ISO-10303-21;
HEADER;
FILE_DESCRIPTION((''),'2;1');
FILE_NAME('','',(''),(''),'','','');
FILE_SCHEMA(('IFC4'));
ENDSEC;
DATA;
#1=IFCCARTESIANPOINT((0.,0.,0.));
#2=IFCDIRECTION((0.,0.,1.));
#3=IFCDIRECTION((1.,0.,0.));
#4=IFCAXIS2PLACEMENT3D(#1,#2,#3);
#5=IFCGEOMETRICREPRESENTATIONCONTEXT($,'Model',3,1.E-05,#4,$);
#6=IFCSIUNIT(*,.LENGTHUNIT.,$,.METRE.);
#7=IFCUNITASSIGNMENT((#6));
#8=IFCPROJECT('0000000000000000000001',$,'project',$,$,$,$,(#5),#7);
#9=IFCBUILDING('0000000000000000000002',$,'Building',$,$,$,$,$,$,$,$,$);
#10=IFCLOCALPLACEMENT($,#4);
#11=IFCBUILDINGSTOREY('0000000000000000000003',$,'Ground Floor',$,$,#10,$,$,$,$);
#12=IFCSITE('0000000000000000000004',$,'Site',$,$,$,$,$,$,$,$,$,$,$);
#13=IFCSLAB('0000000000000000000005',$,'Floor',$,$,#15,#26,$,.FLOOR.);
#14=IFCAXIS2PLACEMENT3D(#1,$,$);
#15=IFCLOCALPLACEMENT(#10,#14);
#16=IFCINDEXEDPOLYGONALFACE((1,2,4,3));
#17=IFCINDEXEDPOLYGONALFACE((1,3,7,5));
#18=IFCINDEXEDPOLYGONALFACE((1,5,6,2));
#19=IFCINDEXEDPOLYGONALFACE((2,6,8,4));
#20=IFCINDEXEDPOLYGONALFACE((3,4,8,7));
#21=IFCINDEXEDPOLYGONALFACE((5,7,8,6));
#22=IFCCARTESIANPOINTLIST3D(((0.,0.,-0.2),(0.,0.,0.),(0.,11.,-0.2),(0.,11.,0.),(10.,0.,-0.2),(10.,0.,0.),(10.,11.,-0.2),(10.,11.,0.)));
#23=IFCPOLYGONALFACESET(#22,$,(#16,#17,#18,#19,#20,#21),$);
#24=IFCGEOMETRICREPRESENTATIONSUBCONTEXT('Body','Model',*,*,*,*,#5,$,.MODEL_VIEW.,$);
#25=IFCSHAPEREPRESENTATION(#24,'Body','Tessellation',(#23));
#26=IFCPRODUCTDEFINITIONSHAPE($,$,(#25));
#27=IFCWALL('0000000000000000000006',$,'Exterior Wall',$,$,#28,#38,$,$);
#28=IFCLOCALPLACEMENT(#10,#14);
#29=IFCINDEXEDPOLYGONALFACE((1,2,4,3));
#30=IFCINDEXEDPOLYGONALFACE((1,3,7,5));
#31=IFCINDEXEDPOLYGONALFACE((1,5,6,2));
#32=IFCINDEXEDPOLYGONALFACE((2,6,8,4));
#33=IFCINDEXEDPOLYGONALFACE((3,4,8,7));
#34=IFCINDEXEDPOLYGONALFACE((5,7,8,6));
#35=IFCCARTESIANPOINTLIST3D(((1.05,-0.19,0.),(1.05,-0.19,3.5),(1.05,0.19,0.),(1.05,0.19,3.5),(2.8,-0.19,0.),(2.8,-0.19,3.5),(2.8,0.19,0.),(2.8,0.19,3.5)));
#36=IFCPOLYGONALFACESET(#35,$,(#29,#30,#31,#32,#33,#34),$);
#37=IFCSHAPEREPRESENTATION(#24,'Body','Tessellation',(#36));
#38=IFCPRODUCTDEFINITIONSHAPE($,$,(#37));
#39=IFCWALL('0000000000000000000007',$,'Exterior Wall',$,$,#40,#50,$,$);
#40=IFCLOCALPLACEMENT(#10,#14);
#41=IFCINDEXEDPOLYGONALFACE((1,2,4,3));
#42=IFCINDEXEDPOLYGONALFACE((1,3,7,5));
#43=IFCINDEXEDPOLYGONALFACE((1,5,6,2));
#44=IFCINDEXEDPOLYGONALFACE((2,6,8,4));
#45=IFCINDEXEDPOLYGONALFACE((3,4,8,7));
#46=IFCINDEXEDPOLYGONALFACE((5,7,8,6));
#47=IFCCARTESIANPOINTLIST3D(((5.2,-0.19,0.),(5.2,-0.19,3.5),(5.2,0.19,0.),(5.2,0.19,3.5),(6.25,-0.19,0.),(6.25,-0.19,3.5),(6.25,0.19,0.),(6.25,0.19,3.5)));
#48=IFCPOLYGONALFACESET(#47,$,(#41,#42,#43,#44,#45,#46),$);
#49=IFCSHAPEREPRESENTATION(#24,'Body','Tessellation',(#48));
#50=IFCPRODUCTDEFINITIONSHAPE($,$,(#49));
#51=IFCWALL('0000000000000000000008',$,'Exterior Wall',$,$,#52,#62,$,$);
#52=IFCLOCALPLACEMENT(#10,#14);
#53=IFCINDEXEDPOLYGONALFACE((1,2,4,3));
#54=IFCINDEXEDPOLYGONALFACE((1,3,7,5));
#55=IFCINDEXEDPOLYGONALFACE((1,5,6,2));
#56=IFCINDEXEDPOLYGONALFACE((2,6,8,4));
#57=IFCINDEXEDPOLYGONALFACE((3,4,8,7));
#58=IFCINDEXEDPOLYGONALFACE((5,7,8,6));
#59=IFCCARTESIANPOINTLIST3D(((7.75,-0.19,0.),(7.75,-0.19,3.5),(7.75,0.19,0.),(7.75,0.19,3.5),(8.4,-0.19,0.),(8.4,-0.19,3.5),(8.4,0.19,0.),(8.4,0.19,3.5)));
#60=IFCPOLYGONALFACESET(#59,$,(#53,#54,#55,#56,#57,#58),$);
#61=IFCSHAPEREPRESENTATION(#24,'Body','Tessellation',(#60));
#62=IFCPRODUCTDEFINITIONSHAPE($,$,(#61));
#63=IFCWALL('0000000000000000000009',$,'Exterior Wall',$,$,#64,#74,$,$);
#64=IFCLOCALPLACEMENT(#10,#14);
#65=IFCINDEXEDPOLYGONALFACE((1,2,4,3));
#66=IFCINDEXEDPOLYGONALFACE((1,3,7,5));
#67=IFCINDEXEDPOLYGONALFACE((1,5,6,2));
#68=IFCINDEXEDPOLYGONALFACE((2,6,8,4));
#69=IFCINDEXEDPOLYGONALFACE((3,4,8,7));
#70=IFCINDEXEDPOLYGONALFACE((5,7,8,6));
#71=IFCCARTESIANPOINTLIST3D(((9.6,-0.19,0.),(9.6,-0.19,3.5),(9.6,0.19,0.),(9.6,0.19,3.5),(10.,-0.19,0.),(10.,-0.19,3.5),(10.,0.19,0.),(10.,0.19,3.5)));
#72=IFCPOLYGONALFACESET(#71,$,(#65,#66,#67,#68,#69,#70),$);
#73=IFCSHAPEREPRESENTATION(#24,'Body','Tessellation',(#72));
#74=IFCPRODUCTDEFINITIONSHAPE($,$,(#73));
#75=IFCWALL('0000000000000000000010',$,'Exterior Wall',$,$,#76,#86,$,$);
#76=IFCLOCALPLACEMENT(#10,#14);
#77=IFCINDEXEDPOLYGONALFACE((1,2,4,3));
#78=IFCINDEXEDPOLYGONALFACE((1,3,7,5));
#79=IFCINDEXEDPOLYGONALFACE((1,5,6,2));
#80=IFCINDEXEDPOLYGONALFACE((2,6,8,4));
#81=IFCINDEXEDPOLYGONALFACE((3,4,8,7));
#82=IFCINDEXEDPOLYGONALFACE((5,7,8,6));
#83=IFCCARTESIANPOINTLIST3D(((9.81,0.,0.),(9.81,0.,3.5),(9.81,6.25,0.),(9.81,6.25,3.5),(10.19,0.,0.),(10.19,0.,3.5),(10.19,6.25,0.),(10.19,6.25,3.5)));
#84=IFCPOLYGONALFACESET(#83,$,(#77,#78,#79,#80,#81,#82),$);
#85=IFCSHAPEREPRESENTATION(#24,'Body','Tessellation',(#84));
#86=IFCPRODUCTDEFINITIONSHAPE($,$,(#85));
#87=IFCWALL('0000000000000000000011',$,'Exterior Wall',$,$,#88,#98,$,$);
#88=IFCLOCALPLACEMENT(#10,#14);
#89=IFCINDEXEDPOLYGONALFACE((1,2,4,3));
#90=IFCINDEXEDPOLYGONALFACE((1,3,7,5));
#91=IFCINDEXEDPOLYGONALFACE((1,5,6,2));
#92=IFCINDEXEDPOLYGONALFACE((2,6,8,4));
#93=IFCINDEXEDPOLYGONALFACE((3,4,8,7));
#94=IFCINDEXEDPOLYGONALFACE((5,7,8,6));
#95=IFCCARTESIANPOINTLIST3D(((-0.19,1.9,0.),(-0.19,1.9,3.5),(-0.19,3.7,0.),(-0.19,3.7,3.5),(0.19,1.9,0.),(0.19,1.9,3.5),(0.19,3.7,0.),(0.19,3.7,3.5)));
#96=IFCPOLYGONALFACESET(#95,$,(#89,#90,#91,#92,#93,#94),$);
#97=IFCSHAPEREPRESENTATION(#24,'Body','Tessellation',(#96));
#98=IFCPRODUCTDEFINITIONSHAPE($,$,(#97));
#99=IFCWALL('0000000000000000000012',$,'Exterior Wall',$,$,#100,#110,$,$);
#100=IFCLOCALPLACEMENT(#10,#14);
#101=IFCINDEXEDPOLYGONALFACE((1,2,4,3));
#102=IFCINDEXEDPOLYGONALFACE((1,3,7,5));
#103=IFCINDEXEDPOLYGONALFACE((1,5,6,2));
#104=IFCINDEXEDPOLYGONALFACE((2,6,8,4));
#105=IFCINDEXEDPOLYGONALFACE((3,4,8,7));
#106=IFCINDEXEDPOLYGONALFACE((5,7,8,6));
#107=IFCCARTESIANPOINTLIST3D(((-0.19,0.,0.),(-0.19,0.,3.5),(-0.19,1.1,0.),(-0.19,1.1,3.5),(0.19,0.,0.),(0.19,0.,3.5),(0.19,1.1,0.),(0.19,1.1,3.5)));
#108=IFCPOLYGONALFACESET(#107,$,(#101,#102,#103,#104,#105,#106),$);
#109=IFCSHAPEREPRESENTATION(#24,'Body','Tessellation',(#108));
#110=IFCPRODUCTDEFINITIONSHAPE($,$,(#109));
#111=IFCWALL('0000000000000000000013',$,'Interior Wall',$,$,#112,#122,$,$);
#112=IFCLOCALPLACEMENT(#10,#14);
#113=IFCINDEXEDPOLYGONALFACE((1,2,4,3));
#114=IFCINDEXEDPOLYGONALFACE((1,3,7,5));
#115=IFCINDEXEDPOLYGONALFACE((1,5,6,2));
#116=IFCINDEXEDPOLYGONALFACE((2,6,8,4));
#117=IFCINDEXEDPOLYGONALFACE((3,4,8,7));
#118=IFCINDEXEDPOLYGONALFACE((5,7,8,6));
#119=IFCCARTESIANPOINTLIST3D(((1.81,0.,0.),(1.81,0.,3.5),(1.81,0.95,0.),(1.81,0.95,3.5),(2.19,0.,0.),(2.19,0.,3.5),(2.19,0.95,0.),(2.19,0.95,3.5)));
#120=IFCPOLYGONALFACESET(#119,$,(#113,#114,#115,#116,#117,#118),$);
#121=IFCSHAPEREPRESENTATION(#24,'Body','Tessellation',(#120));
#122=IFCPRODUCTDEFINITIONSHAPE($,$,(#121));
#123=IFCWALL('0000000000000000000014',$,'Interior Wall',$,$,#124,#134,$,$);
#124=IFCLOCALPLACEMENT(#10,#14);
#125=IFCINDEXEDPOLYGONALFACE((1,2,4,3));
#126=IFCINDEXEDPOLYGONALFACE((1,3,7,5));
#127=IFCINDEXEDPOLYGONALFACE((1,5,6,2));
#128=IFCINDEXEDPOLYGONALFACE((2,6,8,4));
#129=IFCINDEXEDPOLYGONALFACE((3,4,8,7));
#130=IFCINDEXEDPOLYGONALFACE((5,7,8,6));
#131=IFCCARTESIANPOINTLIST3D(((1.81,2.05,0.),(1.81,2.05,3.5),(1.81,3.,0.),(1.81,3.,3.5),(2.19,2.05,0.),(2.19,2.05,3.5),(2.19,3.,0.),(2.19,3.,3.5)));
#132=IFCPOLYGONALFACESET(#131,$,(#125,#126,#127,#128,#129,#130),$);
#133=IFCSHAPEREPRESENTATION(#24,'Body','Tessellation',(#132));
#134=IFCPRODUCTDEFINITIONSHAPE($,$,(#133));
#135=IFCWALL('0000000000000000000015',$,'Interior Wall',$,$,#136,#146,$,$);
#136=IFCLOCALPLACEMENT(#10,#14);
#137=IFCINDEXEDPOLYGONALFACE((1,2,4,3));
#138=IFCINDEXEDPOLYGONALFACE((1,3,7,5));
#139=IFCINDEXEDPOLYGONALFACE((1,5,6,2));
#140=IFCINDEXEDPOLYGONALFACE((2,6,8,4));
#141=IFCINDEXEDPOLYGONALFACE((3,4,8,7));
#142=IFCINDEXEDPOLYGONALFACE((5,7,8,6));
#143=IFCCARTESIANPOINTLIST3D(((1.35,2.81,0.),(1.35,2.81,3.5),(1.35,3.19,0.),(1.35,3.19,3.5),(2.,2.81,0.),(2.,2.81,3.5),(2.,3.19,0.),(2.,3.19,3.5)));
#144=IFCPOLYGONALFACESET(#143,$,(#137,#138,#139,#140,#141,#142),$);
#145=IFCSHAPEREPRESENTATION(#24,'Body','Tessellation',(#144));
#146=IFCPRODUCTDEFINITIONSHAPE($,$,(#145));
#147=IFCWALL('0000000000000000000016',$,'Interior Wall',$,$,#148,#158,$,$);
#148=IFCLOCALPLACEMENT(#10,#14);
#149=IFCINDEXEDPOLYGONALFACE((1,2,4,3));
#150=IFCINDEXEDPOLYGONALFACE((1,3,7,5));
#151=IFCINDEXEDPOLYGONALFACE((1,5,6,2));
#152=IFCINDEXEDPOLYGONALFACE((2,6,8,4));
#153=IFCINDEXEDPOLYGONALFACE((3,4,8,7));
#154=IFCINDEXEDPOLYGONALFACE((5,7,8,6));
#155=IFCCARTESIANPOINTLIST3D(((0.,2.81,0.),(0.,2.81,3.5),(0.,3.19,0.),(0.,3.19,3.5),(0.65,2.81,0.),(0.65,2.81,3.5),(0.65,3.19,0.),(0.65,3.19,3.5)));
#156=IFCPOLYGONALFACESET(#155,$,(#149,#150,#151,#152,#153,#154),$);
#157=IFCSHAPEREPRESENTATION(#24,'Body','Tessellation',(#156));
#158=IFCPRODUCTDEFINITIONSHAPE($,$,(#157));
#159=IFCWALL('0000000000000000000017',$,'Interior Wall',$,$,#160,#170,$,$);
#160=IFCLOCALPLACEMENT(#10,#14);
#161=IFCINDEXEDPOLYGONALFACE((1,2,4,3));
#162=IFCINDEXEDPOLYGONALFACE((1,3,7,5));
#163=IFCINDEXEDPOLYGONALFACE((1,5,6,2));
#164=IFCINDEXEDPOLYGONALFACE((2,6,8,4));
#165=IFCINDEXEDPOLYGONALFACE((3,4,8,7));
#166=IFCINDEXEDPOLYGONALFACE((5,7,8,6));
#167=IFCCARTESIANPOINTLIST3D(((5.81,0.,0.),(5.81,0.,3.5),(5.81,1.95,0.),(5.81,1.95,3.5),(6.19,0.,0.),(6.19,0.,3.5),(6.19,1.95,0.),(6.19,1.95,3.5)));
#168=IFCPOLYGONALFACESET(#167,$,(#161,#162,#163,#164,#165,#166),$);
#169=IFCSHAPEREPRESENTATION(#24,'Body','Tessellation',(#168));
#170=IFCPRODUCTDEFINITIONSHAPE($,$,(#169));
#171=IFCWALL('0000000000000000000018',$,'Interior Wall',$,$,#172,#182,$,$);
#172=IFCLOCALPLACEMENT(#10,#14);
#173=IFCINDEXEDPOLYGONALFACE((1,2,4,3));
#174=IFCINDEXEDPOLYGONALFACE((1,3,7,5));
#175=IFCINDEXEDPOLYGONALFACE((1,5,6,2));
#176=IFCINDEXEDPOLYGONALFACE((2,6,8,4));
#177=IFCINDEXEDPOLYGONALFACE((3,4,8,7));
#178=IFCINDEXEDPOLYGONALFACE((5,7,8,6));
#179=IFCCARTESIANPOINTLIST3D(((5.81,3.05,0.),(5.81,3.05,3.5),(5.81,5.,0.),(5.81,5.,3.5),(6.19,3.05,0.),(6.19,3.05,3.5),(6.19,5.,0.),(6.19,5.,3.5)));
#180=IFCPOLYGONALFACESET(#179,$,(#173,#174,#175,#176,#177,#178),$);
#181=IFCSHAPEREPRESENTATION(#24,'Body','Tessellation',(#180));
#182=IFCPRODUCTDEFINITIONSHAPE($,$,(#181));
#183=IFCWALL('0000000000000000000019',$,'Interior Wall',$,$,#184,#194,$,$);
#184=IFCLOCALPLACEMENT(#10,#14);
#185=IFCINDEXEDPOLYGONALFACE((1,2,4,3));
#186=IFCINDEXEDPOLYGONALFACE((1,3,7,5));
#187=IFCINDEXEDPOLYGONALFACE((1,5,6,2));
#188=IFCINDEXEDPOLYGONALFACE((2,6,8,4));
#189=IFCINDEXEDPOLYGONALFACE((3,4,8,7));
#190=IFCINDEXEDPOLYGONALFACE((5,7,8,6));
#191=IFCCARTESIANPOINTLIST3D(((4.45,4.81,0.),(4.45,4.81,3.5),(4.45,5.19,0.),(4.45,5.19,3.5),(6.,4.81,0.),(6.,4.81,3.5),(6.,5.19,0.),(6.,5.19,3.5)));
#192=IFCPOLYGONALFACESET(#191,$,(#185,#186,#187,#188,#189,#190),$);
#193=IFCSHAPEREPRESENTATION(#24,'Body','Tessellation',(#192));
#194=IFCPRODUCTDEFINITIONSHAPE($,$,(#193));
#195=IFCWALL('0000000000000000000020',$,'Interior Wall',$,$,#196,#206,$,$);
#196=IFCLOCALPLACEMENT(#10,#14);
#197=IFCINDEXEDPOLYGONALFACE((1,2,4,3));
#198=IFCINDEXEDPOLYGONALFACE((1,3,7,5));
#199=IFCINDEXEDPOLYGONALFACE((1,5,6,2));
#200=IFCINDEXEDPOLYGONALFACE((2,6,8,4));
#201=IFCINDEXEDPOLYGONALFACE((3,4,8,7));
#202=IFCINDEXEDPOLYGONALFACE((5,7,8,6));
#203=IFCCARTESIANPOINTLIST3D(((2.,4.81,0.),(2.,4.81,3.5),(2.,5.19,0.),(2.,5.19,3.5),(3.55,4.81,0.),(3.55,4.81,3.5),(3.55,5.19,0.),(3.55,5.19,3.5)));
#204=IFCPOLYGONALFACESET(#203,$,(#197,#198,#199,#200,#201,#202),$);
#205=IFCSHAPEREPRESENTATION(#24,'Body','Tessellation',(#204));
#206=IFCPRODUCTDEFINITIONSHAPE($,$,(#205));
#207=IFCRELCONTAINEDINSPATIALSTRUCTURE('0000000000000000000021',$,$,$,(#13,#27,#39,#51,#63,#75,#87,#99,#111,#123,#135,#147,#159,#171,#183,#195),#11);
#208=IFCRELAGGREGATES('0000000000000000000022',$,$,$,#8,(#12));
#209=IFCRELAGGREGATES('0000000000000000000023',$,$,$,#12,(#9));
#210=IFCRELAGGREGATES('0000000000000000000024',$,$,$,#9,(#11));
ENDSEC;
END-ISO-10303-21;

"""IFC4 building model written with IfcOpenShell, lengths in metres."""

from ifc_helpers import new_model, si_unit, frame, origin_with_axes, place, context, subcontext, project, spatial, indexed_curve, outline, extrude, element, save


model = new_model("IFC4")

# Units and contexts
model_context = context("Model", 3, precision=1e-05, world=origin_with_axes())
body_context = subcontext(model_context, "Body", "Model", "MODEL_VIEW")
ifc_project = project(units=[si_unit("LENGTHUNIT", "METRE")], contexts=[model_context])

# Site, building, storey
site = spatial("IfcSite", under=ifc_project, Name="Site")
building = spatial("IfcBuilding", under=site, Name="Building")
storey_placement = place(None, origin_with_axes())
storey = spatial("IfcBuildingStorey", under=building, at=storey_placement, Name="Ground Floor")

# Slab
slab_placement = place(storey_placement, frame((0.0, 0.0, -0.2), z_axis=(0.0, 0.0, 1.0), x_axis=(1.0, 0.0, 0.0)))
element("IfcSlab", 1, at=slab_placement, inside=storey, Name="Floor", PredefinedType="FLOOR", context=body_context, shape_type="SweptSolid", body=[
    extrude(outline(indexed_curve([(0.0, 0.0), (10.0, 0.0), (10.0, 11.0), (0.0, 11.0)])), None, (0.0, 0.0, 1.0), 0.2),
])

# Walls
wall_1_placement = place(storey_placement, frame((1.05, 0.0, 0.0), z_axis=(0.0, 0.0, 1.0), x_axis=(1.0, 0.0, 0.0)))
element("IfcWall", 2, at=wall_1_placement, inside=storey, Name="Exterior Wall", context=body_context, shape_type="SweptSolid", body=[
    extrude(outline(indexed_curve([(0.0, 0.0), (0.0, 0.38), (1.75, 0.38), (1.75, 0.0), (0.0, 0.0)], self_intersect=False)), frame((0.0, -0.19, 0.0), z_axis=(0.0, 0.0, 1.0), x_axis=(1.0, 0.0, 0.0)), (0.0, 0.0, 1.0), 3.5),
])
wall_2_placement = place(storey_placement, frame((5.2, 0.0, 0.0), z_axis=(0.0, 0.0, 1.0), x_axis=(1.0, 0.0, 0.0)))
element("IfcWall", 3, at=wall_2_placement, inside=storey, Name="Exterior Wall", context=body_context, shape_type="SweptSolid", body=[
    extrude(outline(indexed_curve([(0.0, 0.0), (0.0, 0.38), (1.05, 0.38), (1.05, 0.0), (0.0, 0.0)], self_intersect=False)), frame((0.0, -0.19, 0.0), z_axis=(0.0, 0.0, 1.0), x_axis=(1.0, 0.0, 0.0)), (0.0, 0.0, 1.0), 3.5),
])
wall_3_placement = place(storey_placement, frame((7.75, 0.0, 0.0), z_axis=(0.0, 0.0, 1.0), x_axis=(1.0, 0.0, 0.0)))
element("IfcWall", 4, at=wall_3_placement, inside=storey, Name="Exterior Wall", context=body_context, shape_type="SweptSolid", body=[
    extrude(outline(indexed_curve([(0.0, 0.0), (0.0, 0.38), (0.65, 0.38), (0.65, 0.0), (0.0, 0.0)], self_intersect=False)), frame((0.0, -0.19, 0.0), z_axis=(0.0, 0.0, 1.0), x_axis=(1.0, 0.0, 0.0)), (0.0, 0.0, 1.0), 3.5),
])
wall_4_placement = place(storey_placement, frame((9.6, 0.0, 0.0), z_axis=(0.0, 0.0, 1.0), x_axis=(1.0, 0.0, 0.0)))
element("IfcWall", 5, at=wall_4_placement, inside=storey, Name="Exterior Wall", context=body_context, shape_type="SweptSolid", body=[
    extrude(outline(indexed_curve([(0.0, 0.0), (0.0, 0.38), (0.4, 0.38), (0.4, 0.0), (0.0, 0.0)], self_intersect=False)), frame((0.0, -0.19, 0.0), z_axis=(0.0, 0.0, 1.0), x_axis=(1.0, 0.0, 0.0)), (0.0, 0.0, 1.0), 3.5),
])
wall_5_placement = place(storey_placement, frame((10.0, 0.0, 0.0), z_axis=(0.0, 0.0, 1.0), x_axis=(0.0, 1.0, 0.0)))
element("IfcWall", 6, at=wall_5_placement, inside=storey, Name="Exterior Wall", context=body_context, shape_type="SweptSolid", body=[
    extrude(outline(indexed_curve([(0.0, 0.0), (0.0, 0.38), (6.25, 0.38), (6.25, 0.0), (0.0, 0.0)], self_intersect=False)), frame((0.0, -0.19, 0.0), z_axis=(0.0, 0.0, 1.0), x_axis=(1.0, 0.0, 0.0)), (0.0, 0.0, 1.0), 3.5),
])
wall_6_placement = place(storey_placement, frame((0.0, 3.7, 0.0), z_axis=(0.0, 0.0, 1.0), x_axis=(0.0, -1.0, 0.0)))
element("IfcWall", 7, at=wall_6_placement, inside=storey, Name="Exterior Wall", context=body_context, shape_type="SweptSolid", body=[
    extrude(outline(indexed_curve([(0.0, 0.0), (0.0, 0.38), (1.8, 0.38), (1.8, 0.0), (0.0, 0.0)], self_intersect=False)), frame((0.0, -0.19, 0.0), z_axis=(0.0, 0.0, 1.0), x_axis=(1.0, 0.0, 0.0)), (0.0, 0.0, 1.0), 3.5),
])
wall_7_placement = place(storey_placement, frame((0.0, 1.1, 0.0), z_axis=(0.0, 0.0, 1.0), x_axis=(0.0, -1.0, 0.0)))
element("IfcWall", 8, at=wall_7_placement, inside=storey, Name="Exterior Wall", context=body_context, shape_type="SweptSolid", body=[
    extrude(outline(indexed_curve([(0.0, 0.0), (0.0, 0.38), (1.1, 0.38), (1.1, 0.0), (0.0, 0.0)], self_intersect=False)), frame((0.0, -0.19, 0.0), z_axis=(0.0, 0.0, 1.0), x_axis=(1.0, 0.0, 0.0)), (0.0, 0.0, 1.0), 3.5),
])
wall_8_placement = place(storey_placement, frame((2.0, 0.0, 0.0), z_axis=(0.0, 0.0, 1.0), x_axis=(0.0, 1.0, 0.0)))
element("IfcWall", 9, at=wall_8_placement, inside=storey, Name="Interior Wall", context=body_context, shape_type="SweptSolid", body=[
    extrude(outline(indexed_curve([(0.0, 0.0), (0.0, 0.38), (0.95, 0.38), (0.95, 0.0), (0.0, 0.0)], self_intersect=False)), frame((0.0, -0.19, 0.0), z_axis=(0.0, 0.0, 1.0), x_axis=(1.0, 0.0, 0.0)), (0.0, 0.0, 1.0), 3.5),
])
wall_9_placement = place(storey_placement, frame((2.0, 2.05, 0.0), z_axis=(0.0, 0.0, 1.0), x_axis=(0.0, 1.0, 0.0)))
element("IfcWall", 10, at=wall_9_placement, inside=storey, Name="Interior Wall", context=body_context, shape_type="SweptSolid", body=[
    extrude(outline(indexed_curve([(0.0, 0.0), (0.0, 0.38), (0.95, 0.38), (0.95, 0.0), (0.0, 0.0)], self_intersect=False)), frame((0.0, -0.19, 0.0), z_axis=(0.0, 0.0, 1.0), x_axis=(1.0, 0.0, 0.0)), (0.0, 0.0, 1.0), 3.5),
])
for number, where, z_axis, x_axis, name in (
    (11, (2.0, 3.0, 0.0), (0.0, 0.0, 1.0), (-1.0, 0.0, 0.0), "Interior Wall"),
    (12, (0.65, 3.0, 0.0), (0.0, 0.0, 1.0), (-1.0, 0.0, 0.0), "Interior Wall"),
):
    element("IfcWall", number, at=place(storey_placement, frame(where, z_axis=z_axis, x_axis=x_axis)), inside=storey, Name=name, context=body_context, shape_type="SweptSolid", body=[
        extrude(outline(indexed_curve([(0.0, 0.0), (0.0, 0.38), (0.65, 0.38), (0.65, 0.0), (0.0, 0.0)], self_intersect=False)), frame((0.0, -0.19, 0.0), z_axis=(0.0, 0.0, 1.0), x_axis=(1.0, 0.0, 0.0)), (0.0, 0.0, 1.0), 3.5),
    ])
wall_10_placement = place(storey_placement, frame((6.0, 0.0, 0.0), z_axis=(0.0, 0.0, 1.0), x_axis=(0.0, 1.0, 0.0)))
element("IfcWall", 13, at=wall_10_placement, inside=storey, Name="Interior Wall", context=body_context, shape_type="SweptSolid", body=[
    extrude(outline(indexed_curve([(0.0, 0.0), (0.0, 0.38), (1.95, 0.38), (1.95, 0.0), (0.0, 0.0)], self_intersect=False)), frame((0.0, -0.19, 0.0), z_axis=(0.0, 0.0, 1.0), x_axis=(1.0, 0.0, 0.0)), (0.0, 0.0, 1.0), 3.5),
])
wall_11_placement = place(storey_placement, frame((6.0, 3.05, 0.0), z_axis=(0.0, 0.0, 1.0), x_axis=(0.0, 1.0, 0.0)))
element("IfcWall", 14, at=wall_11_placement, inside=storey, Name="Interior Wall", context=body_context, shape_type="SweptSolid", body=[
    extrude(outline(indexed_curve([(0.0, 0.0), (0.0, 0.38), (1.95, 0.38), (1.95, 0.0), (0.0, 0.0)], self_intersect=False)), frame((0.0, -0.19, 0.0), z_axis=(0.0, 0.0, 1.0), x_axis=(1.0, 0.0, 0.0)), (0.0, 0.0, 1.0), 3.5),
])
for number, where, z_axis, x_axis, name in (
    (15, (6.0, 5.0, 0.0), (0.0, 0.0, 1.0), (-1.0, 0.0, 0.0), "Interior Wall"),
    (16, (3.55, 5.0, 0.0), (0.0, 0.0, 1.0), (-1.0, 0.0, 0.0), "Interior Wall"),
):
    element("IfcWall", number, at=place(storey_placement, frame(where, z_axis=z_axis, x_axis=x_axis)), inside=storey, Name=name, context=body_context, shape_type="SweptSolid", body=[
        extrude(outline(indexed_curve([(0.0, 0.0), (0.0, 0.38), (1.55, 0.38), (1.55, 0.0), (0.0, 0.0)], self_intersect=False)), frame((0.0, -0.19, 0.0), z_axis=(0.0, 0.0, 1.0), x_axis=(1.0, 0.0, 0.0)), (0.0, 0.0, 1.0), 3.5),
    ])

save(model, "model.ifc")
